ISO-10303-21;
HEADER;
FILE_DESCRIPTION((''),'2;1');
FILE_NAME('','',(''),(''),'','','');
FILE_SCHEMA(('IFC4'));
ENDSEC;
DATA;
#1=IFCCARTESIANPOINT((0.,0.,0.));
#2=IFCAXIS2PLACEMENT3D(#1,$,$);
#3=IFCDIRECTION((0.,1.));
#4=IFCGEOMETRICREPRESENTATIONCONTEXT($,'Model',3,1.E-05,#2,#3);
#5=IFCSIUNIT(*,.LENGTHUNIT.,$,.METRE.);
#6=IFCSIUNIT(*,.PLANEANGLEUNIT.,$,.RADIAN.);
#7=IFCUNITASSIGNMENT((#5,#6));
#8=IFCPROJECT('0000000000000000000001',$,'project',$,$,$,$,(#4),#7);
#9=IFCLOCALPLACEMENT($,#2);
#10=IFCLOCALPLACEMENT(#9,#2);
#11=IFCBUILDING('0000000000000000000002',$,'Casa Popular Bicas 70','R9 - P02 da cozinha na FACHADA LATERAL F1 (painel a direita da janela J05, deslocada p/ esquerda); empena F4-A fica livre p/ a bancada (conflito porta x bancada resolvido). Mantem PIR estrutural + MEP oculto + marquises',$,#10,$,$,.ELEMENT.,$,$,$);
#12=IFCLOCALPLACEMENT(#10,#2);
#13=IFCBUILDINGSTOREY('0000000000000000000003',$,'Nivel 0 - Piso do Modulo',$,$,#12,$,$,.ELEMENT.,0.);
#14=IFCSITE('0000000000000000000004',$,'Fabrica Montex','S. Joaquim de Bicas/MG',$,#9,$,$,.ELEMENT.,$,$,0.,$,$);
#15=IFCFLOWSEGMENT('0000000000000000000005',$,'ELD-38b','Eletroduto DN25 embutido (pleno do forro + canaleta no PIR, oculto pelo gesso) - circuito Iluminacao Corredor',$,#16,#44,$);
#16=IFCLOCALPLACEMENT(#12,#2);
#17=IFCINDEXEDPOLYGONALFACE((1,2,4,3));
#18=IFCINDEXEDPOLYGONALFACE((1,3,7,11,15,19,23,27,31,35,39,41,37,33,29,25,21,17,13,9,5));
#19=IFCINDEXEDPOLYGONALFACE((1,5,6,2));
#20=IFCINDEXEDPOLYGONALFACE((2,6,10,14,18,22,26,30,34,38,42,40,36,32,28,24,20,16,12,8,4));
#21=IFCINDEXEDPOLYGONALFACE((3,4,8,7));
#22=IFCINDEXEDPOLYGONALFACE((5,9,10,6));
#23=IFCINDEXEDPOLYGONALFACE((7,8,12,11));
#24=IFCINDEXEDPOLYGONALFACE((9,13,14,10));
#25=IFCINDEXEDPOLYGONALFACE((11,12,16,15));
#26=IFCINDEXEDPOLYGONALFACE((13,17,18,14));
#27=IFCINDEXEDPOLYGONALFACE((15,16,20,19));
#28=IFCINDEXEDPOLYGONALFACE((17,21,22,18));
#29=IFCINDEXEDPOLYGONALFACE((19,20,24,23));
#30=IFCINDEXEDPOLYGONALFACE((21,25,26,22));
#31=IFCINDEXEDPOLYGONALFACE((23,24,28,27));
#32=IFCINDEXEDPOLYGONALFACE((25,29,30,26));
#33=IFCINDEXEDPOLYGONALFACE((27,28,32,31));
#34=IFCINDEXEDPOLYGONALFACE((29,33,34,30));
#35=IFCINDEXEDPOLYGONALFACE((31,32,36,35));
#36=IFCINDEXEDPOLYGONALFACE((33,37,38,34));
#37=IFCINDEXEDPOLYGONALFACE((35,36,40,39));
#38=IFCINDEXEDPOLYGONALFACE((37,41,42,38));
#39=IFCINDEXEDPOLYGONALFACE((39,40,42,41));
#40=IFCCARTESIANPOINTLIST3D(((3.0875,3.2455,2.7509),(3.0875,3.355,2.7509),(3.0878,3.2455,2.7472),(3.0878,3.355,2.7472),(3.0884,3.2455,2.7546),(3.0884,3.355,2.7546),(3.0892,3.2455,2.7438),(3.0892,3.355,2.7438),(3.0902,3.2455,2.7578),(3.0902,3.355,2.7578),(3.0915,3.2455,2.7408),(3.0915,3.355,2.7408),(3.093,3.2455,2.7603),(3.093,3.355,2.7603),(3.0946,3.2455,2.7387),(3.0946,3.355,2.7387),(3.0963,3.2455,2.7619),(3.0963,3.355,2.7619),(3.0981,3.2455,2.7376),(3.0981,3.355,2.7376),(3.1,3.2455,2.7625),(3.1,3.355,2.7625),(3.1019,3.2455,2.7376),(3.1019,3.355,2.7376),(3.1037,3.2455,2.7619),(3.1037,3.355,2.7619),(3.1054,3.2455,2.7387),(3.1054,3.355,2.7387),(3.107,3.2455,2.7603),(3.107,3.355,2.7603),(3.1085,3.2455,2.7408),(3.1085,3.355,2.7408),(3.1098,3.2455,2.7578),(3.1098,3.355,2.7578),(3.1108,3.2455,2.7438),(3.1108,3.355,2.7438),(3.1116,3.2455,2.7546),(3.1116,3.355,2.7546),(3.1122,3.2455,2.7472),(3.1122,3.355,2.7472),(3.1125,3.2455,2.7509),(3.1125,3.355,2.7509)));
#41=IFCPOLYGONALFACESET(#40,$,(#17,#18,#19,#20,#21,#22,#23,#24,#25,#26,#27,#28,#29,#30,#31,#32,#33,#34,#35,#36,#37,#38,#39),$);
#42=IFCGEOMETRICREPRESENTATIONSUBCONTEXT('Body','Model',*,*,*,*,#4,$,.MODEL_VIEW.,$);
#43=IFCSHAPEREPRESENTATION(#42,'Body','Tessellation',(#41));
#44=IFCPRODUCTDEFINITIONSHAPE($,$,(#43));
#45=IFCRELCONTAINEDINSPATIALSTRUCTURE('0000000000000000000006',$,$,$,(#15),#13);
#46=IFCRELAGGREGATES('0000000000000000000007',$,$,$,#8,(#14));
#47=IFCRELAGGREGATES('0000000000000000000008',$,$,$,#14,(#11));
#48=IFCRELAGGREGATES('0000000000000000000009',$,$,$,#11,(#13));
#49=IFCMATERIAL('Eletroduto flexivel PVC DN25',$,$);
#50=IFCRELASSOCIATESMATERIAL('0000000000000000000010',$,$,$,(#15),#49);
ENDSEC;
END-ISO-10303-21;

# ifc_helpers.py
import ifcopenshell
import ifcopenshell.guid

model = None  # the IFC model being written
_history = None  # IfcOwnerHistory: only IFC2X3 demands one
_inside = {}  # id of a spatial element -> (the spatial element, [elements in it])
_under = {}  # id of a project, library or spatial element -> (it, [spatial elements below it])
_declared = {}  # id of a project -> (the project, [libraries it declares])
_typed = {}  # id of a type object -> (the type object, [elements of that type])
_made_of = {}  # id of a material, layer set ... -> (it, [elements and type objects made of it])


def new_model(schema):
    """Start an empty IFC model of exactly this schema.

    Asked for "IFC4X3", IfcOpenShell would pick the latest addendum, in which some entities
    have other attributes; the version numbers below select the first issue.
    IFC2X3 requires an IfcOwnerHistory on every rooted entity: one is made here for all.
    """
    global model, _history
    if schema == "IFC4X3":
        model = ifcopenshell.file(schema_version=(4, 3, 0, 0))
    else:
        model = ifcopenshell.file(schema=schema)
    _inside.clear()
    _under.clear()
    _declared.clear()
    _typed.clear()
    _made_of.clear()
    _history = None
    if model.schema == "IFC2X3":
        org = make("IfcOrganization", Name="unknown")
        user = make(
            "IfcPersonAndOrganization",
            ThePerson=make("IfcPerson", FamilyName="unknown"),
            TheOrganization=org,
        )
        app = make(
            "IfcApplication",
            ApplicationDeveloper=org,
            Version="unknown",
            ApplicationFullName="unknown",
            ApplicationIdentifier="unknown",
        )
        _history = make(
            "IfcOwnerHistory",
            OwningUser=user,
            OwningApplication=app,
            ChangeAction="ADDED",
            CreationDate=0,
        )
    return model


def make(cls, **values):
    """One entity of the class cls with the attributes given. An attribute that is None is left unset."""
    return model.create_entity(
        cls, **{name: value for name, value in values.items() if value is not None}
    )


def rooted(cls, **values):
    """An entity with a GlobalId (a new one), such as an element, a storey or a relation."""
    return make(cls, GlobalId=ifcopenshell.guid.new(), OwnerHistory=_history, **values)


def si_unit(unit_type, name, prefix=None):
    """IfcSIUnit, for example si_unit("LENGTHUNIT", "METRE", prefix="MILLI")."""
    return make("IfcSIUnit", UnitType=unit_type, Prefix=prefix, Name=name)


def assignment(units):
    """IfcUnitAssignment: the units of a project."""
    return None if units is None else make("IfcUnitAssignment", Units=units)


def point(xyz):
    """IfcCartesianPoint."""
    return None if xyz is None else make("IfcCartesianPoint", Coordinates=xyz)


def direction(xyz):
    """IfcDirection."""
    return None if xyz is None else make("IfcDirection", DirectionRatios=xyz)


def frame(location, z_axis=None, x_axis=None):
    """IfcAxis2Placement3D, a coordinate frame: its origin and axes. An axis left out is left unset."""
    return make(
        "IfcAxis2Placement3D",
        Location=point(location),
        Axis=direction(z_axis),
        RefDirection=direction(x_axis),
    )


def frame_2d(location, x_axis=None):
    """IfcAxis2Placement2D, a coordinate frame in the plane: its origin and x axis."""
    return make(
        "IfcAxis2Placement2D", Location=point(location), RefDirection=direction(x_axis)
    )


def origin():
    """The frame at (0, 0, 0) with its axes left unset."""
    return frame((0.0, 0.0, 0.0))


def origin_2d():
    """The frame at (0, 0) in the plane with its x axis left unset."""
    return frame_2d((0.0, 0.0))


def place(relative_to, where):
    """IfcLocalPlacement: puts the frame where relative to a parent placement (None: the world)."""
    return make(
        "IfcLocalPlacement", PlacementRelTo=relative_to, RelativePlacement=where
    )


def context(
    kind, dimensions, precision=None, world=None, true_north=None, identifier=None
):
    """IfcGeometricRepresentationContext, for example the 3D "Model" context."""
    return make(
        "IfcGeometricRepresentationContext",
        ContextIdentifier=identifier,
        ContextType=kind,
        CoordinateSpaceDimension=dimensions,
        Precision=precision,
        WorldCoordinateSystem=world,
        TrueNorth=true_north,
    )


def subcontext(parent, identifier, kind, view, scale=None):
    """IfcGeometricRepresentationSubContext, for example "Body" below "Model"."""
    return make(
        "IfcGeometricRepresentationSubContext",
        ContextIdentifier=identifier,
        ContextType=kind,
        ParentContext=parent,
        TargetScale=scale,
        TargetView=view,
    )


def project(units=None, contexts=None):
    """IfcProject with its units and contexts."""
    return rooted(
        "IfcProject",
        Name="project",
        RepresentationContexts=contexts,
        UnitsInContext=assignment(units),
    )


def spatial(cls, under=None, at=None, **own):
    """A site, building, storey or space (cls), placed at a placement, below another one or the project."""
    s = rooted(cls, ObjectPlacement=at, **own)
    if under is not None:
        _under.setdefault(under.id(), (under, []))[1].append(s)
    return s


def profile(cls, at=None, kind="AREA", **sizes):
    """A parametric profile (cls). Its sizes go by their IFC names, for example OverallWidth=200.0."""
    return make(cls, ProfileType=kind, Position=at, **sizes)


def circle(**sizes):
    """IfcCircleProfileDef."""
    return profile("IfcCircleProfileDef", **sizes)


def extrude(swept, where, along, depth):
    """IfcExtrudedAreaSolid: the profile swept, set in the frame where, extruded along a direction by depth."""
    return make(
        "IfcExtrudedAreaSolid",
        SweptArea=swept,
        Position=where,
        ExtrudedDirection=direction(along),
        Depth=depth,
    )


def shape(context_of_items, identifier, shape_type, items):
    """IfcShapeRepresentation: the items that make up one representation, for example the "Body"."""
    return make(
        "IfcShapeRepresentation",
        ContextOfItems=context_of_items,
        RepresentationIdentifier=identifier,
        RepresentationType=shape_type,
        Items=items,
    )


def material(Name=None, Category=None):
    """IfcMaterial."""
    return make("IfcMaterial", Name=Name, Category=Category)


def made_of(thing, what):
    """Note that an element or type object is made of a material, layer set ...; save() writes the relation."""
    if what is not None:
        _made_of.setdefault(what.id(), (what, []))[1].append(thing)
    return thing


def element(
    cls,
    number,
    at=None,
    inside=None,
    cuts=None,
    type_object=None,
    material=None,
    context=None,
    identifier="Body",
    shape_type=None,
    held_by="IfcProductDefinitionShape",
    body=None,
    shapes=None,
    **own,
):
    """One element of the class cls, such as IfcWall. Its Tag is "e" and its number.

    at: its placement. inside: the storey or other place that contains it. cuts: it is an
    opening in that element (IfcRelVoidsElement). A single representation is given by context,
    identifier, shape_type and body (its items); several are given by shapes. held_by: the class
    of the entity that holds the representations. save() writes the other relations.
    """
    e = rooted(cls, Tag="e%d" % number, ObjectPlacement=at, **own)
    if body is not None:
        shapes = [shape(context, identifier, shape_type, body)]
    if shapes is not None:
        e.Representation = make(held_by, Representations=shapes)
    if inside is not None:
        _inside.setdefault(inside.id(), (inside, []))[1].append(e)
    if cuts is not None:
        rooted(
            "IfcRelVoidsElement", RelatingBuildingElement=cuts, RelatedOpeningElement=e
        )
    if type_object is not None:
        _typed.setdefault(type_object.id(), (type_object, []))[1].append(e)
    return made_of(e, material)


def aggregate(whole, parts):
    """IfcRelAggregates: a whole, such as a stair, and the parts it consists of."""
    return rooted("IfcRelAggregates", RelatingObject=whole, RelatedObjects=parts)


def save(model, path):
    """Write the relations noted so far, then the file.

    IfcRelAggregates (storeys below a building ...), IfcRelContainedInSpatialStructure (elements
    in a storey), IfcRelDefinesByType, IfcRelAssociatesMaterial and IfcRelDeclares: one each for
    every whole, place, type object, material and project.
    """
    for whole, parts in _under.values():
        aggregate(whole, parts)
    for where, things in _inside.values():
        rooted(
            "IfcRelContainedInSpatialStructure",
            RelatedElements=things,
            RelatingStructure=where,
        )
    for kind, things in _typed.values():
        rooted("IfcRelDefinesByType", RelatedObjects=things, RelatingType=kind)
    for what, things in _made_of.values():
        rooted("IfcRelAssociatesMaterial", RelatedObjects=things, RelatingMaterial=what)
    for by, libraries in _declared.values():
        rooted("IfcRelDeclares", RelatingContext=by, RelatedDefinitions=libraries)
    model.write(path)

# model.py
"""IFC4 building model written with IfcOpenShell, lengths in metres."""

from ifc_helpers import new_model, si_unit, direction, frame, origin, origin_2d, place, context, subcontext, project, spatial, circle, extrude, material, element, save


model = new_model("IFC4")

# Units and contexts
model_context = context("Model", 3, precision=1e-05, world=origin(), true_north=direction((0.0, 1.0)))
body_context = subcontext(model_context, "Body", "Model", "MODEL_VIEW")
ifc_project = project(units=[si_unit("LENGTHUNIT", "METRE"), si_unit("PLANEANGLEUNIT", "RADIAN")], contexts=[model_context])

# Site, building, storey
site_placement = place(None, origin())
site = spatial("IfcSite", under=ifc_project, at=site_placement, Name="Fabrica Montex", Description="S. Joaquim de Bicas/MG", CompositionType="ELEMENT", RefElevation=0.0)
building_placement = place(site_placement, origin())
building = spatial("IfcBuilding", under=site, at=building_placement, Name="Casa Popular Bicas 70", Description="R9 - P02 da cozinha na FACHADA LATERAL F1 (painel a direita da janela J05, deslocada p/ esquerda); empena F4-A fica livre p/ a bancada (conflito porta x bancada resolvido). Mantem PIR estrutural + MEP oculto + marquises", CompositionType="ELEMENT")
storey_placement = place(building_placement, origin())
storey = spatial("IfcBuildingStorey", under=building, at=storey_placement, Name="Nivel 0 - Piso do Modulo", CompositionType="ELEMENT", Elevation=0.0)

# Shared definitions
ifc_material_1 = material(Name="Eletroduto flexivel PVC DN25")

# Flow segment
flow_segment_1_placement = place(storey_placement, frame((3.1, 3.2455, 2.75), z_axis=(0.0, 1.0, 0.0), x_axis=(0.0, 0.0, 1.0)))
element("IfcFlowSegment", 1, at=flow_segment_1_placement, inside=storey, material=ifc_material_1, Name="ELD-38b", Description="Eletroduto DN25 embutido (pleno do forro + canaleta no PIR, oculto pelo gesso) - circuito Iluminacao Corredor", context=body_context, shape_type="SweptSolid", body=[
    extrude(circle(Radius=0.0125, at=origin_2d()), origin(), (0.0, 0.0, 1.0), 0.1095),
])

save(model, "model.ifc")
